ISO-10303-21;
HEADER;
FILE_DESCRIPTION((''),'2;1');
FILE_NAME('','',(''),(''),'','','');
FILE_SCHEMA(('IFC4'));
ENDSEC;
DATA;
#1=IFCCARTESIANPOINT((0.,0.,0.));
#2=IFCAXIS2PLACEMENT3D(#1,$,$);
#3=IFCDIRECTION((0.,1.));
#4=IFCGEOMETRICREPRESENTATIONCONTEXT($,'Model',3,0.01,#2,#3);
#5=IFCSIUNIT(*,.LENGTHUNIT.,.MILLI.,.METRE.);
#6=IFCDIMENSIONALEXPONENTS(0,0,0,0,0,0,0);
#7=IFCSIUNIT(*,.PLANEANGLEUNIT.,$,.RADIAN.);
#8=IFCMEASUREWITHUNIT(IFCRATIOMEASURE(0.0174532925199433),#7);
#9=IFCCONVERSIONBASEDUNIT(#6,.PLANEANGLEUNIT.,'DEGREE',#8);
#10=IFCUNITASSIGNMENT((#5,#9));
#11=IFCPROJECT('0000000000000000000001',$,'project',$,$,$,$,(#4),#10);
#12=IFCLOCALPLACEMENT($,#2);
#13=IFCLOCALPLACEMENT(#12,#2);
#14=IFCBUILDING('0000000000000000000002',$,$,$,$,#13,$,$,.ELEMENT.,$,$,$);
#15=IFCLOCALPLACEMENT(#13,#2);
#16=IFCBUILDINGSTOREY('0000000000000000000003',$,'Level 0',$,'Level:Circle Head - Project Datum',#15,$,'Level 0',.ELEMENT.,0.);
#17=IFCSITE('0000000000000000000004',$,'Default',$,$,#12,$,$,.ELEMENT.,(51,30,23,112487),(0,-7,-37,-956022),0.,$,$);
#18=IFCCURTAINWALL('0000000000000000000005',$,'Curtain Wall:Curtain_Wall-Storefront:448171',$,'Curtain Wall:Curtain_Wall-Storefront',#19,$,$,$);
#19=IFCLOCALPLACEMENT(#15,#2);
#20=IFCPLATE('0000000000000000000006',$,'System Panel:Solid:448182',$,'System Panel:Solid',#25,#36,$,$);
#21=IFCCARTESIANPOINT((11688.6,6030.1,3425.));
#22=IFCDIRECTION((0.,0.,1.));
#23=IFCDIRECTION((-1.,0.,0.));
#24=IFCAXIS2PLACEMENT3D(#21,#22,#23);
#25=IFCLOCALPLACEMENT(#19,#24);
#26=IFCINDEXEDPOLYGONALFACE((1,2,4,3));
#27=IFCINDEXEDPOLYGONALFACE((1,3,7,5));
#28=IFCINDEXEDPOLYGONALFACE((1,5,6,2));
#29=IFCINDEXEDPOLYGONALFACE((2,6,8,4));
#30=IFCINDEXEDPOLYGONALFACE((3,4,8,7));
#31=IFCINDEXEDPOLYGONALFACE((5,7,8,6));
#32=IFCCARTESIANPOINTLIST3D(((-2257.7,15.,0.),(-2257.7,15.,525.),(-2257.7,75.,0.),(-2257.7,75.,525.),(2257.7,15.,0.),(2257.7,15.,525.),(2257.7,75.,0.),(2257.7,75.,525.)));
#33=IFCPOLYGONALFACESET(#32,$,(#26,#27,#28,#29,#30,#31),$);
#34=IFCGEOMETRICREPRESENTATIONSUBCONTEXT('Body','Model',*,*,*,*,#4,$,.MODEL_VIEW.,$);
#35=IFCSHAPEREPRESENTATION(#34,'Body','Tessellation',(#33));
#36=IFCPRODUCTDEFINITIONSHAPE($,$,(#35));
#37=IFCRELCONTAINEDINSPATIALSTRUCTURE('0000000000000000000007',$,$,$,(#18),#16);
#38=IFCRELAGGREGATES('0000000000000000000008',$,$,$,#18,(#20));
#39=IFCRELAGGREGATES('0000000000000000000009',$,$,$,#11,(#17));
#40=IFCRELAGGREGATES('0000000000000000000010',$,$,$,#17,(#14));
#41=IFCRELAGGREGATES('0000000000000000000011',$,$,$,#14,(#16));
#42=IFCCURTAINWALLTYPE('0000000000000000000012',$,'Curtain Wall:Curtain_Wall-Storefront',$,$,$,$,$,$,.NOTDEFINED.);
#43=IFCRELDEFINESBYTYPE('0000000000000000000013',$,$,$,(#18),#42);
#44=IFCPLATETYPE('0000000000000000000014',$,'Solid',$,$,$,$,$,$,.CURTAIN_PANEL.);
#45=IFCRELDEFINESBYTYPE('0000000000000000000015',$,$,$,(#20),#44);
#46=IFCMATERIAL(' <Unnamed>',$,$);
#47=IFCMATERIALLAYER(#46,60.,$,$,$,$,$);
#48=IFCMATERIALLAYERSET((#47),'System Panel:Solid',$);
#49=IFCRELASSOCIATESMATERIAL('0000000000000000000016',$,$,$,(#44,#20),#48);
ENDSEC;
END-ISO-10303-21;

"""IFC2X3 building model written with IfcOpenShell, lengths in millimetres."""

from ifc_helpers import new_model, entity, si_unit, converted_unit, direction, frame, frame_2d, origin, place, context, subcontext, project, spatial, rectangle, extrude, source, transform, mapped, material, layer, layer_set, layer_usage, type_object, type_shapes, element, aggregate, save


model = new_model("IFC2X3")

# Units and contexts
model_context = context("Model", 3, precision=0.01, world=origin(), true_north=direction((0.0, 1.0)))
body_context = subcontext(model_context, "Body", "Model", "MODEL_VIEW")
ifc_project = project(units=[si_unit("LENGTHUNIT", "METRE", prefix="MILLI"), converted_unit("PLANEANGLEUNIT", "DEGREE", entity("IfcRatioMeasure", 0.0174532925199433), si_unit("PLANEANGLEUNIT", "RADIAN"), dimensions=[0, 0, 0, 0, 0, 0, 0])], contexts=[model_context])

# Site, building, storey
site_placement = place(None, origin())
site = spatial("IfcSite", under=ifc_project, at=site_placement, Name="Default", CompositionType="ELEMENT", RefLatitude=(51, 30, 23, 112487), RefLongitude=(0, -7, -37, -956022), RefElevation=0.0)
building_placement = place(site_placement, origin())
building = spatial("IfcBuilding", under=site, at=building_placement, CompositionType="ELEMENT")
storey_placement = place(building_placement, origin())
storey = spatial("IfcBuildingStorey", under=building, at=storey_placement, Name="Level 0", ObjectType="Level:Circle Head - Project Datum", LongName="Level 0", CompositionType="ELEMENT", Elevation=0.0)

# Curtain wall
curtain_wall_type = type_object("IfcCurtainWallType", Name="Curtain Wall:Curtain_Wall-Storefront", PredefinedType="NOTDEFINED")
curtain_wall_1_placement = place(storey_placement, origin())
curtain_wall_1 = element("IfcCurtainWall", 1, at=curtain_wall_1_placement, inside=storey, type_object=curtain_wall_type, Name="Curtain Wall:Curtain_Wall-Storefront:448171", ObjectType="Curtain Wall:Curtain_Wall-Storefront")

# Plate
ifc_material_1 = material(Name=" <Unnamed>")
ifc_layer_1 = layer(ifc_material_1, 60.0)
ifc_layer_set_1 = layer_set([ifc_layer_1], Name="System Panel:Solid")
ifc_layer_usage_1 = layer_usage(ifc_layer_set_1, "AXIS3", "POSITIVE", 0.1)
plate_type_1 = type_object("IfcPlateType", Name="Solid", PredefinedType="CURTAIN_PANEL", material=ifc_layer_set_1)
shared_shape_1 = source(origin(), body_context, "Body", "SweptSolid", [
    extrude(rectangle(XDim=525.0, YDim=4515.5, at=frame_2d((0.0, 1.4), x_axis=(1.0, 0.0))), frame((-1.4, 15.0, 262.5), z_axis=(0.0, 1.0, 0.0), x_axis=(0.0, 0.0, 1.0)), (0.0, 0.0, 1.0), 60.0),
])
type_shapes(plate_type_1, [shared_shape_1])
plate_1_placement = place(curtain_wall_1_placement, frame((11688.6, 6030.1, 3425.0), z_axis=(0.0, 0.0, 1.0), x_axis=(-1.0, 0.0, 0.0)))
plate_1 = element("IfcPlate", 2, at=plate_1_placement, type_object=plate_type_1, material=ifc_layer_usage_1, Name="System Panel:Solid:448182", ObjectType="System Panel:Solid", context=body_context, shape_type="MappedRepresentation", body=[
    mapped(shared_shape_1, transform((0.0, 0.0, 0.0), scale=1.0)),
])
aggregate(curtain_wall_1, [plate_1])

save(model, "model.ifc")
